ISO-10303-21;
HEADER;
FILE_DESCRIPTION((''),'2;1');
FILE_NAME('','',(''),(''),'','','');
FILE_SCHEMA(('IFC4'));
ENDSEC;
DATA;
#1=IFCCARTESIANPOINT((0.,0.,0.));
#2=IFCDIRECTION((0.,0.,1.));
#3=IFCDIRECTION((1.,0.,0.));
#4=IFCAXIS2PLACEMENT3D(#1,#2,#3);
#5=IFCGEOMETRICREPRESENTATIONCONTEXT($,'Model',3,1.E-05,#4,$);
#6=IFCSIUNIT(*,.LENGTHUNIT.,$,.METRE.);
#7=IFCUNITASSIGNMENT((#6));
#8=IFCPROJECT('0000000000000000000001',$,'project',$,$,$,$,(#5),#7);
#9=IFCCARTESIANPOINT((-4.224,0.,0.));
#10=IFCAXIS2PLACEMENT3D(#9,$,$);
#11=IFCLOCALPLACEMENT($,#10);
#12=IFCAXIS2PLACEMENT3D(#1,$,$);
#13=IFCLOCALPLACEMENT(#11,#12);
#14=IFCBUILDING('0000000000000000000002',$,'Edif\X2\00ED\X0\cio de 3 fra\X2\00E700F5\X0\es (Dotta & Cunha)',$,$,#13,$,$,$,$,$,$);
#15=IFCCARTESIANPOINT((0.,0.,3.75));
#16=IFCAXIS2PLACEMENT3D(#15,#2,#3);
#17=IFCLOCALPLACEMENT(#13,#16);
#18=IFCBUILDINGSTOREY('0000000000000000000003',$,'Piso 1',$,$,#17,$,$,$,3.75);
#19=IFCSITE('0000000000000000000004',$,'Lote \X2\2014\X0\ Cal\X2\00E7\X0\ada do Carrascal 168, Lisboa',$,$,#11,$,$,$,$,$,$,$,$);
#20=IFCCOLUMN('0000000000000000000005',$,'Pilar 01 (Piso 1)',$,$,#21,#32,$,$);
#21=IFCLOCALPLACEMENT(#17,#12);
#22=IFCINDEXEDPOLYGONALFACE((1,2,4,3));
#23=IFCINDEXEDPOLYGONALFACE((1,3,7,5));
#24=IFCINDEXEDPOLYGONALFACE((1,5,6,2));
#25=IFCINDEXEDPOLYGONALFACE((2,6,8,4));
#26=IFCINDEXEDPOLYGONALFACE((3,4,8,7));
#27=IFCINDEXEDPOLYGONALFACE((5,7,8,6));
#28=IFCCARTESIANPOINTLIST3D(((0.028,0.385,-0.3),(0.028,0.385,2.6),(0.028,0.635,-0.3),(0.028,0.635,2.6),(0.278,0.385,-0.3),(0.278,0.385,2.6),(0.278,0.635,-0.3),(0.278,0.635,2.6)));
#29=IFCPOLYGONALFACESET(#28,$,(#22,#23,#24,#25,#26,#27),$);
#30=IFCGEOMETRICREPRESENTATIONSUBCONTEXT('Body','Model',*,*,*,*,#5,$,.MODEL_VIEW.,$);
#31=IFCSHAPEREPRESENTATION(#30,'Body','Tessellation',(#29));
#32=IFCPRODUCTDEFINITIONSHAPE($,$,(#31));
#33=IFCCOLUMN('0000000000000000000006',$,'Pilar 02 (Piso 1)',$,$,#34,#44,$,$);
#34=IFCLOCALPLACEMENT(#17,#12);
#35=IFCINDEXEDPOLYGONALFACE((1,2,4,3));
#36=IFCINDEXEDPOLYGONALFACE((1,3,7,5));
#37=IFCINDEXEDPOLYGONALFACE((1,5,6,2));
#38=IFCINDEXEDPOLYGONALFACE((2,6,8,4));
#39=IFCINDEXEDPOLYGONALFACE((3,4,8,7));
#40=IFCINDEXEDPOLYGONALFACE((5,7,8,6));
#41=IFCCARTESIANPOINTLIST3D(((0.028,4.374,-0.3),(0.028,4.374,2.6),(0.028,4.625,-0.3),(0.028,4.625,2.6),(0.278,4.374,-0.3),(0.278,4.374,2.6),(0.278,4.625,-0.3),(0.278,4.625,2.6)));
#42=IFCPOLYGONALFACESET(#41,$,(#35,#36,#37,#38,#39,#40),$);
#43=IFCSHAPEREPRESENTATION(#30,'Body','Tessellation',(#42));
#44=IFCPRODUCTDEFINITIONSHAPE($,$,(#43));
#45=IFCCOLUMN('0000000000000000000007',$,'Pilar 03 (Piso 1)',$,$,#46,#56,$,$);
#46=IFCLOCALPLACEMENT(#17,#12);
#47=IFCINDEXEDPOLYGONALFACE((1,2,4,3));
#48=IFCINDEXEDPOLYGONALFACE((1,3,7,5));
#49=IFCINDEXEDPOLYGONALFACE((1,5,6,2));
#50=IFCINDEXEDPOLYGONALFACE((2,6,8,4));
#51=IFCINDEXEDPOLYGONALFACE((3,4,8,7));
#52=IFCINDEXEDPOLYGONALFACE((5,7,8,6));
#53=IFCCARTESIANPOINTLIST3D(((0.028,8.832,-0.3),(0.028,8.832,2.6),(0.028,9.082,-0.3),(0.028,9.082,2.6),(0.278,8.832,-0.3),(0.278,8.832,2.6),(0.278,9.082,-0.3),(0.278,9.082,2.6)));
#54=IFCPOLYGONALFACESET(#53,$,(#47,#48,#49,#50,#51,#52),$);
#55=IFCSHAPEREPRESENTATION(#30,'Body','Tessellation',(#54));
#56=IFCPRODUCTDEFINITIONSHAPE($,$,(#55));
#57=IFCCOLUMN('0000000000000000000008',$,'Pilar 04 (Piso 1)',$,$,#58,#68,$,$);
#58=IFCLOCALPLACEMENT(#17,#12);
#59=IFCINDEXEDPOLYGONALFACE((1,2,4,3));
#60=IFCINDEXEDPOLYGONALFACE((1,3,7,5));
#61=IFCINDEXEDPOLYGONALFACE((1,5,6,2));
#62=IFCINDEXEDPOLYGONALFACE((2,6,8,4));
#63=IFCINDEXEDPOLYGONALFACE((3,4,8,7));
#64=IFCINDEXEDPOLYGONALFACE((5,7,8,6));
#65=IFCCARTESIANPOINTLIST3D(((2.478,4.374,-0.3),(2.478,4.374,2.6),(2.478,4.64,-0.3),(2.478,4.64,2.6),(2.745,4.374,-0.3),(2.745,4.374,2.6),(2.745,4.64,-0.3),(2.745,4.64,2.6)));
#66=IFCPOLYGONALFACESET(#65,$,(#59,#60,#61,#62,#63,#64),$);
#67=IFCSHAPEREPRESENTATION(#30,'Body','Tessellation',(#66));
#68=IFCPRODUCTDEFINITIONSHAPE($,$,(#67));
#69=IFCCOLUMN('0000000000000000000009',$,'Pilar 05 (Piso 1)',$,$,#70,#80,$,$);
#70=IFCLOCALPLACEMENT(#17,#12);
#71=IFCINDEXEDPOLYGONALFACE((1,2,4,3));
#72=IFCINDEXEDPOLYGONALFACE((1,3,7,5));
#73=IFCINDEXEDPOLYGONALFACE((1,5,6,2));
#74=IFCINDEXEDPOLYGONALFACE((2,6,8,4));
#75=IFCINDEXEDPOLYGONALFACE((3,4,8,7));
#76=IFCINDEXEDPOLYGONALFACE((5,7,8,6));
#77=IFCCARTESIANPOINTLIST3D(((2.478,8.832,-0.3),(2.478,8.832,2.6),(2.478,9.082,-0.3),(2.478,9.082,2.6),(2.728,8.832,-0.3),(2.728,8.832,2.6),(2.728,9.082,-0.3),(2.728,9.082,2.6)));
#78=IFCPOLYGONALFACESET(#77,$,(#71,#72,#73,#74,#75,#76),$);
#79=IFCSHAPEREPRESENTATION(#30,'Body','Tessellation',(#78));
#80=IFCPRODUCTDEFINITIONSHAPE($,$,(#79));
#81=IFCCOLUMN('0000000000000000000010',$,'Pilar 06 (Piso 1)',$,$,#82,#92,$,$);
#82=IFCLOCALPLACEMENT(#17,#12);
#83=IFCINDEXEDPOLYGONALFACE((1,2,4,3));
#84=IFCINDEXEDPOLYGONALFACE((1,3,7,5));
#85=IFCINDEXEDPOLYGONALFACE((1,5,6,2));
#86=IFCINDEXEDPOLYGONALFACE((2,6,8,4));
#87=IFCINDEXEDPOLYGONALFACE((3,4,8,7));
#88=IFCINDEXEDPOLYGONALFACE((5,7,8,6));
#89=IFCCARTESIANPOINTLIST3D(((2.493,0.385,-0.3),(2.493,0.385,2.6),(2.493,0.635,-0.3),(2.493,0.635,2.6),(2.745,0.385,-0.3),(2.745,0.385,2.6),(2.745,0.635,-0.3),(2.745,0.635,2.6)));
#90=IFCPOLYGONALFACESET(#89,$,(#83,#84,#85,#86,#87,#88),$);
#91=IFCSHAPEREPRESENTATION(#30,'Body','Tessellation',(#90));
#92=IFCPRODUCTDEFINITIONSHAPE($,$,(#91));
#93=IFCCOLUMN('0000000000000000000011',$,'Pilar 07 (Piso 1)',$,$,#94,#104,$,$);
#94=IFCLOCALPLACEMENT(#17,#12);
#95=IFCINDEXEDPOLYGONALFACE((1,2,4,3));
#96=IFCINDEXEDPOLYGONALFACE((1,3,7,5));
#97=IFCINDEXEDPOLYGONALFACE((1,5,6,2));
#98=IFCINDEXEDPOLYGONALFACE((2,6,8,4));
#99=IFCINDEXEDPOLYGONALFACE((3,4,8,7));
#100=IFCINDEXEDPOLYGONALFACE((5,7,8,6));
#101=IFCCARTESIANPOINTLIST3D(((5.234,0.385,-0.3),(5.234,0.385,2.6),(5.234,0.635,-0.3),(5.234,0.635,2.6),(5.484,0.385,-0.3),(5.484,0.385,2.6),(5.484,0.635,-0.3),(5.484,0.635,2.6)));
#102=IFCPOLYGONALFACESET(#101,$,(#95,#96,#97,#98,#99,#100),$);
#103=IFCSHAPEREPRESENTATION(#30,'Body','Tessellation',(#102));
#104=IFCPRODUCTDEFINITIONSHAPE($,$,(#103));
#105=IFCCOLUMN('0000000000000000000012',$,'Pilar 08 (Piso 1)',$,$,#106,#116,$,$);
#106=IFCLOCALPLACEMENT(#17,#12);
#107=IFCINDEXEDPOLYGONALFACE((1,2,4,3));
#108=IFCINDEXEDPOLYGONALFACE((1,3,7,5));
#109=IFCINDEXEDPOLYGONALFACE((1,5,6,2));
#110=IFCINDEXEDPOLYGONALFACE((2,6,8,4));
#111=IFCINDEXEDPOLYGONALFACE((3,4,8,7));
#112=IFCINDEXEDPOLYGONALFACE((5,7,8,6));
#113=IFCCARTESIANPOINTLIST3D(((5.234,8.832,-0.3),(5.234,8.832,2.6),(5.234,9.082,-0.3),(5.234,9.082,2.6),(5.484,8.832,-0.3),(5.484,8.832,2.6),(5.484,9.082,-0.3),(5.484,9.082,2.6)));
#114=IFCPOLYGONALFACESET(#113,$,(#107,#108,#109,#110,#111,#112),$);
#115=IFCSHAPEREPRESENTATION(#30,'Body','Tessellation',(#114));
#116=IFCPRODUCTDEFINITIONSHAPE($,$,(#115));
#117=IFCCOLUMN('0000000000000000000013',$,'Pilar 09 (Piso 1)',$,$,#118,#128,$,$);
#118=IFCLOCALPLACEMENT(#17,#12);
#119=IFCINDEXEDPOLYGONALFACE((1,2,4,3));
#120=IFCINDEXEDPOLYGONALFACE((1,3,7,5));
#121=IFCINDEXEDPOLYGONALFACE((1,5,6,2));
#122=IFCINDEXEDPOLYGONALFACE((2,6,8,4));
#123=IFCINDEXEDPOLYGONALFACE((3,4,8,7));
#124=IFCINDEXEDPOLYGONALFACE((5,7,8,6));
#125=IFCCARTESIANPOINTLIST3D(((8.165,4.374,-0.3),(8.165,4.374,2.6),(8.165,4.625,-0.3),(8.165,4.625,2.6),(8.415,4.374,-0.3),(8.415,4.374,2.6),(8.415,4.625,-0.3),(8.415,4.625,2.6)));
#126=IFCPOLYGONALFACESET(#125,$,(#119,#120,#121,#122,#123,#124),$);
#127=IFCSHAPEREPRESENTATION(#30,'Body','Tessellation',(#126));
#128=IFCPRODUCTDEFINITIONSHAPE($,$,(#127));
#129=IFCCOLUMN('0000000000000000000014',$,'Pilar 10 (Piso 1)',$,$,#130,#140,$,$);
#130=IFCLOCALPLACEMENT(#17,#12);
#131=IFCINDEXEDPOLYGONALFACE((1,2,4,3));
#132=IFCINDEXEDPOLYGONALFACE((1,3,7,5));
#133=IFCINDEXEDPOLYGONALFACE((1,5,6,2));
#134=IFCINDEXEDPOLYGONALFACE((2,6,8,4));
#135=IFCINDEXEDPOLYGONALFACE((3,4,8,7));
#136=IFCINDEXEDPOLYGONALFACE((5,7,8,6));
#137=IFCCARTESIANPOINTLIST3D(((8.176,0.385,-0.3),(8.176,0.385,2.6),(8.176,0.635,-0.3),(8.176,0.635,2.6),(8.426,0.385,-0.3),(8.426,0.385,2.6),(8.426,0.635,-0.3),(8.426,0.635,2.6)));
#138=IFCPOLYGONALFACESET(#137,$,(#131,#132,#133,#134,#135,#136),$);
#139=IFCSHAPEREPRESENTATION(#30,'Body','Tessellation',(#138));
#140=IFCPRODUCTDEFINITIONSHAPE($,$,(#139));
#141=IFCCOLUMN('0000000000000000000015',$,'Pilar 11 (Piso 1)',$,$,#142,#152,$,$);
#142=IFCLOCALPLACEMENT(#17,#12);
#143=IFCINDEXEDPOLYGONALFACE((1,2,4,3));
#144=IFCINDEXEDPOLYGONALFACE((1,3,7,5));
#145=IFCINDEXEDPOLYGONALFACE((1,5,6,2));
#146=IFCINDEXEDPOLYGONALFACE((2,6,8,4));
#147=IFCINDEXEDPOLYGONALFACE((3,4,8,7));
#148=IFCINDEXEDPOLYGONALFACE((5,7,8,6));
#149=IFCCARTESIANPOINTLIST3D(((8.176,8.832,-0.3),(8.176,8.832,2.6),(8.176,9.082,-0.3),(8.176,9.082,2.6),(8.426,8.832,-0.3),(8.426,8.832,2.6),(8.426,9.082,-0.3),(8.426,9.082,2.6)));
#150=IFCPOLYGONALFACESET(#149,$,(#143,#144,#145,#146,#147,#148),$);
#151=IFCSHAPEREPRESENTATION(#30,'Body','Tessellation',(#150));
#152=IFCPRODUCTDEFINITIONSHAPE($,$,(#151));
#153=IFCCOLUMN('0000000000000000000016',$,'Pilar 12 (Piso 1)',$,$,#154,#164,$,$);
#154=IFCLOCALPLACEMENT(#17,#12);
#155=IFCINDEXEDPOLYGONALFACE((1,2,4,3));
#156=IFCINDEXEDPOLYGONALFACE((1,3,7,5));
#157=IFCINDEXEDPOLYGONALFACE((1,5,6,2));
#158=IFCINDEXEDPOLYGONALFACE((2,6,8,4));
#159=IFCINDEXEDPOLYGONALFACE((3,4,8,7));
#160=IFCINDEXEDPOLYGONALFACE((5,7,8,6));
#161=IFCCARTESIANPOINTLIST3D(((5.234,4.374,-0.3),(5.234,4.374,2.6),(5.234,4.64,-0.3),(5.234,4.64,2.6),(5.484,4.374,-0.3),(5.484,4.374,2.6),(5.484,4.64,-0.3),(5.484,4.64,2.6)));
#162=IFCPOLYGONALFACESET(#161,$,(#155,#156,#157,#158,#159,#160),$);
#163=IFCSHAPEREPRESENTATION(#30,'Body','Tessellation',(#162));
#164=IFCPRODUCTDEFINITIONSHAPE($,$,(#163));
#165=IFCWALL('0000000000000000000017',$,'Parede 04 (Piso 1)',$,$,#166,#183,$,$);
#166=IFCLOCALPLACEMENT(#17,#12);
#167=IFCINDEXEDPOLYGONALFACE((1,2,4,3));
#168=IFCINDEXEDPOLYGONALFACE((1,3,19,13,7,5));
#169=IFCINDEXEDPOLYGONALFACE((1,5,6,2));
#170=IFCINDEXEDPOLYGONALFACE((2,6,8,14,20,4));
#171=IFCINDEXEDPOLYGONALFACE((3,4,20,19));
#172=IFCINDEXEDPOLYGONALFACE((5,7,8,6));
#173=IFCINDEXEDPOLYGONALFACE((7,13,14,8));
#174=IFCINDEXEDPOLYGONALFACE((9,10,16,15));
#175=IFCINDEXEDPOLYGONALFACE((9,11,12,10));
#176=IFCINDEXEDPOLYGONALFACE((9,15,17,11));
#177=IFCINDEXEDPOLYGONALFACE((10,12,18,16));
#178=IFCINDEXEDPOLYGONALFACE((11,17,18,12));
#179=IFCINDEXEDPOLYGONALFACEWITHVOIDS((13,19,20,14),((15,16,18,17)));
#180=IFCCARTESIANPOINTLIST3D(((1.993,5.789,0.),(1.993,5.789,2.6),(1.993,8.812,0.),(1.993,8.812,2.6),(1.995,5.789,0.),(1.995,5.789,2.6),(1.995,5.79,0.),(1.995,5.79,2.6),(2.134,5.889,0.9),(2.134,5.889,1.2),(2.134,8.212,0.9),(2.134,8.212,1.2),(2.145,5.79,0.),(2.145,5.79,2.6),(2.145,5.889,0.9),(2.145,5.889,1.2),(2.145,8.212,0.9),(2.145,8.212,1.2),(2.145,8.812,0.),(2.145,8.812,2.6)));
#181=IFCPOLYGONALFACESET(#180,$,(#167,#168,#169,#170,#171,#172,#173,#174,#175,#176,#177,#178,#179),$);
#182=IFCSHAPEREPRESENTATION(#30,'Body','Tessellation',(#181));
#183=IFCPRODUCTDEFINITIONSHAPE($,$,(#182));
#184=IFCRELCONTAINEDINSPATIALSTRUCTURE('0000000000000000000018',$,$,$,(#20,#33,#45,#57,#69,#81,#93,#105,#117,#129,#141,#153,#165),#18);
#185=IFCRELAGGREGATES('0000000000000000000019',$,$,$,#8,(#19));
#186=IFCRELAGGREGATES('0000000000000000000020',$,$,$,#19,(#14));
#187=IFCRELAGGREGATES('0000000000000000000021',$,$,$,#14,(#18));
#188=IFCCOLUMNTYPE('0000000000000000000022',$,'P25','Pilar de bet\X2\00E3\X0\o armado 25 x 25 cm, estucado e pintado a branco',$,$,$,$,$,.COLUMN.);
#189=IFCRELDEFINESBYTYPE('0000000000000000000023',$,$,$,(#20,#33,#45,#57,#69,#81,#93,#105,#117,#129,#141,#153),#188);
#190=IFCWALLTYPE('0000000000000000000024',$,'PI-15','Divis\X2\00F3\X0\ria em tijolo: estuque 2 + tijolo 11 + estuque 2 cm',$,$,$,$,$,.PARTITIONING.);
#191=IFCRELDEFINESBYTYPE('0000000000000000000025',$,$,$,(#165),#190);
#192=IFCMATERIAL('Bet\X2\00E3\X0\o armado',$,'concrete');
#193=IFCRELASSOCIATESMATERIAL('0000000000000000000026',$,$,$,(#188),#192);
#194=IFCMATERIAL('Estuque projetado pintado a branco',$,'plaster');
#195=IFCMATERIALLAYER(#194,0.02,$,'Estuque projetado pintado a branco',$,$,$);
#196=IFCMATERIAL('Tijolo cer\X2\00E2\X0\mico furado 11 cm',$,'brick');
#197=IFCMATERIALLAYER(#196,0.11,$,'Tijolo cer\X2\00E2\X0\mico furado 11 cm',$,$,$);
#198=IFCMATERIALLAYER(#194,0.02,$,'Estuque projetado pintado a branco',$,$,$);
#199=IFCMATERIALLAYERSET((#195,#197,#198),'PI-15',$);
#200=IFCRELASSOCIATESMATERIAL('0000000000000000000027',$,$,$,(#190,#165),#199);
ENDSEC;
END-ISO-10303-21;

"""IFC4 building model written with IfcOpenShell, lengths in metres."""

from ifc_helpers import new_model, si_unit, frame, origin, origin_with_axes, place, context, subcontext, project, spatial, line, indexed_curve, outline, extrude, material, layer, layer_set, layer_usage, type_object, element, save


model = new_model("IFC4")

# Units and contexts
model_context = context("Model", 3, precision=1e-05, world=origin_with_axes())
body_context = subcontext(model_context, "Body", "Model", "MODEL_VIEW")
ifc_project = project(units=[si_unit("LENGTHUNIT", "METRE")], contexts=[model_context])

# Site, building, storey
site_placement = place(None, frame((-4.224, 0.0, 0.0)))
site = spatial("IfcSite", under=ifc_project, at=site_placement, Name="Lote — Calçada do Carrascal 168, Lisboa")
building_placement = place(site_placement, origin())
building = spatial("IfcBuilding", under=site, at=building_placement, Name="Edifício de 3 frações (Dotta & Cunha)")
storey_placement = place(building_placement, frame((0.0, 0.0, 3.75), z_axis=(0.0, 0.0, 1.0), x_axis=(1.0, 0.0, 0.0)))
storey = spatial("IfcBuildingStorey", under=building, at=storey_placement, Name="Piso 1", Elevation=3.75)

# Columns
ifc_material_1 = material(Name="Betão armado", Category="concrete")
column_type = type_object("IfcColumnType", Name="P25", Description="Pilar de betão armado 25 x 25 cm, estucado e pintado a branco", PredefinedType="COLUMN", material=ifc_material_1)
column_1_placement = place(storey_placement, frame((0.0, 0.0, -0.3), z_axis=(0.0, 0.0, 1.0), x_axis=(1.0, 0.0, 0.0)))
element("IfcColumn", 1, at=column_1_placement, inside=storey, type_object=column_type, Name="Pilar 01 (Piso 1)", context=body_context, shape_type="SweptSolid", body=[
    extrude(outline(indexed_curve([(0.278, 0.385), (0.028, 0.385), (0.028, 0.635), (0.278, 0.635)], segments=[line(1, 2, 3, 4, 1)])), origin_with_axes(), (0.0, 0.0, 1.0), 2.9),
])
column_2_placement = place(storey_placement, frame((0.0, 0.0, -0.3), z_axis=(0.0, 0.0, 1.0), x_axis=(1.0, 0.0, 0.0)))
element("IfcColumn", 2, at=column_2_placement, inside=storey, type_object=column_type, Name="Pilar 02 (Piso 1)", context=body_context, shape_type="SweptSolid", body=[
    extrude(outline(indexed_curve([(0.278, 4.374), (0.028, 4.374), (0.028, 4.625), (0.278, 4.625)], segments=[line(1, 2, 3, 4, 1)])), origin_with_axes(), (0.0, 0.0, 1.0), 2.9),
])
column_3_placement = place(storey_placement, frame((0.0, 0.0, -0.3), z_axis=(0.0, 0.0, 1.0), x_axis=(1.0, 0.0, 0.0)))
element("IfcColumn", 3, at=column_3_placement, inside=storey, type_object=column_type, Name="Pilar 03 (Piso 1)", context=body_context, shape_type="SweptSolid", body=[
    extrude(outline(indexed_curve([(0.028, 9.082), (0.278, 9.082), (0.278, 8.832), (0.028, 8.832)], segments=[line(1, 2, 3, 4, 1)])), origin_with_axes(), (0.0, 0.0, 1.0), 2.9),
])
column_4_placement = place(storey_placement, frame((0.0, 0.0, -0.3), z_axis=(0.0, 0.0, 1.0), x_axis=(1.0, 0.0, 0.0)))
element("IfcColumn", 4, at=column_4_placement, inside=storey, type_object=column_type, Name="Pilar 04 (Piso 1)", context=body_context, shape_type="SweptSolid", body=[
    extrude(outline(indexed_curve([(2.478, 4.64), (2.745, 4.64), (2.745, 4.374), (2.478, 4.374)], segments=[line(1, 2, 3, 4, 1)])), origin_with_axes(), (0.0, 0.0, 1.0), 2.9),
])
column_5_placement = place(storey_placement, frame((0.0, 0.0, -0.3), z_axis=(0.0, 0.0, 1.0), x_axis=(1.0, 0.0, 0.0)))
element("IfcColumn", 5, at=column_5_placement, inside=storey, type_object=column_type, Name="Pilar 05 (Piso 1)", context=body_context, shape_type="SweptSolid", body=[
    extrude(outline(indexed_curve([(2.478, 9.082), (2.728, 9.082), (2.728, 8.832), (2.478, 8.832)], segments=[line(1, 2, 3, 4, 1)])), origin_with_axes(), (0.0, 0.0, 1.0), 2.9),
])
column_6_placement = place(storey_placement, frame((0.0, 0.0, -0.3), z_axis=(0.0, 0.0, 1.0), x_axis=(1.0, 0.0, 0.0)))
element("IfcColumn", 6, at=column_6_placement, inside=storey, type_object=column_type, Name="Pilar 06 (Piso 1)", context=body_context, shape_type="SweptSolid", body=[
    extrude(outline(indexed_curve([(2.493, 0.385), (2.493, 0.635), (2.745, 0.635), (2.745, 0.385)], segments=[line(1, 2, 3, 4, 1)])), origin_with_axes(), (0.0, 0.0, 1.0), 2.9),
])
column_7_placement = place(storey_placement, frame((0.0, 0.0, -0.3), z_axis=(0.0, 0.0, 1.0), x_axis=(1.0, 0.0, 0.0)))
element("IfcColumn", 7, at=column_7_placement, inside=storey, type_object=column_type, Name="Pilar 07 (Piso 1)", context=body_context, shape_type="SweptSolid", body=[
    extrude(outline(indexed_curve([(5.234, 0.385), (5.234, 0.635), (5.484, 0.635), (5.484, 0.385)], segments=[line(1, 2, 3, 4, 1)])), origin_with_axes(), (0.0, 0.0, 1.0), 2.9),
])
column_8_placement = place(storey_placement, frame((0.0, 0.0, -0.3), z_axis=(0.0, 0.0, 1.0), x_axis=(1.0, 0.0, 0.0)))
element("IfcColumn", 8, at=column_8_placement, inside=storey, type_object=column_type, Name="Pilar 08 (Piso 1)", context=body_context, shape_type="SweptSolid", body=[
    extrude(outline(indexed_curve([(5.234, 9.082), (5.484, 9.082), (5.484, 8.832), (5.234, 8.832)], segments=[line(1, 2, 3, 4, 1)])), origin_with_axes(), (0.0, 0.0, 1.0), 2.9),
])
column_9_placement = place(storey_placement, frame((0.0, 0.0, -0.3), z_axis=(0.0, 0.0, 1.0), x_axis=(1.0, 0.0, 0.0)))
element("IfcColumn", 9, at=column_9_placement, inside=storey, type_object=column_type, Name="Pilar 09 (Piso 1)", context=body_context, shape_type="SweptSolid", body=[
    extrude(outline(indexed_curve([(8.165, 4.625), (8.415, 4.625), (8.415, 4.374), (8.165, 4.374)], segments=[line(1, 2, 3, 4, 1)])), origin_with_axes(), (0.0, 0.0, 1.0), 2.9),
])
column_10_placement = place(storey_placement, frame((0.0, 0.0, -0.3), z_axis=(0.0, 0.0, 1.0), x_axis=(1.0, 0.0, 0.0)))
element("IfcColumn", 10, at=column_10_placement, inside=storey, type_object=column_type, Name="Pilar 10 (Piso 1)", context=body_context, shape_type="SweptSolid", body=[
    extrude(outline(indexed_curve([(8.176, 0.635), (8.426, 0.635), (8.426, 0.385), (8.176, 0.385)], segments=[line(1, 2, 3, 4, 1)])), origin_with_axes(), (0.0, 0.0, 1.0), 2.9),
])
column_11_placement = place(storey_placement, frame((0.0, 0.0, -0.3), z_axis=(0.0, 0.0, 1.0), x_axis=(1.0, 0.0, 0.0)))
element("IfcColumn", 11, at=column_11_placement, inside=storey, type_object=column_type, Name="Pilar 11 (Piso 1)", context=body_context, shape_type="SweptSolid", body=[
    extrude(outline(indexed_curve([(8.176, 9.082), (8.426, 9.082), (8.426, 8.832), (8.176, 8.832)], segments=[line(1, 2, 3, 4, 1)])), origin_with_axes(), (0.0, 0.0, 1.0), 2.9),
])
column_12_placement = place(storey_placement, frame((0.0, 0.0, -0.3), z_axis=(0.0, 0.0, 1.0), x_axis=(1.0, 0.0, 0.0)))
element("IfcColumn", 12, at=column_12_placement, inside=storey, type_object=column_type, Name="Pilar 12 (Piso 1)", context=body_context, shape_type="SweptSolid", body=[
    extrude(outline(indexed_curve([(5.234, 4.374), (5.234, 4.64), (5.484, 4.64), (5.484, 4.374)], segments=[line(1, 2, 3, 4, 1)])), origin_with_axes(), (0.0, 0.0, 1.0), 2.9),
])

# Wall, opening
ifc_material_2 = material(Name="Estuque projetado pintado a branco", Category="plaster")
ifc_layer_1 = layer(ifc_material_2, 0.02, Name="Estuque projetado pintado a branco")
ifc_material_3 = material(Name="Tijolo cerâmico furado 11 cm", Category="brick")
ifc_layer_2 = layer(ifc_material_3, 0.11, Name="Tijolo cerâmico furado 11 cm")
ifc_layer_3 = layer(ifc_material_2, 0.02, Name="Estuque projetado pintado a branco")
ifc_layer_set_1 = layer_set([ifc_layer_1, ifc_layer_2, ifc_layer_3], Name="PI-15")
ifc_layer_usage_1 = layer_usage(ifc_layer_set_1, "AXIS2", "POSITIVE", 0.0)
wall_type_1 = type_object("IfcWallType", Name="PI-15", Description="Divisória em tijolo: estuque 2 + tijolo 11 + estuque 2 cm", PredefinedType="PARTITIONING", material=ifc_layer_set_1)
wall_1_placement = place(storey_placement, origin_with_axes())
wall_1 = element("IfcWall", 13, at=wall_1_placement, inside=storey, type_object=wall_type_1, material=ifc_layer_usage_1, Name="Parede 04 (Piso 1)", context=body_context, shape_type="SweptSolid", body=[
    extrude(outline(indexed_curve([(1.995, 5.789), (1.993, 5.789), (1.993, 5.79), (1.993, 8.812), (2.145, 8.812), (2.145, 5.79), (1.995, 5.79)], segments=[line(1, 2, 3, 4, 5, 6, 7, 1)])), origin_with_axes(), (0.0, 0.0, 1.0), 2.6),
])
opening_1_placement = place(wall_1_placement, frame((0.0, 0.0, 0.9), z_axis=(0.0, 0.0, 1.0), x_axis=(1.0, 0.0, 0.0)))
element("IfcOpeningElement", 14, at=opening_1_placement, cuts=wall_1, PredefinedType="RECESS", context=body_context, shape_type="SweptSolid", body=[
    extrude(outline(indexed_curve([(2.15, 5.889), (2.15, 8.212), (2.134, 8.212), (2.134, 5.889)], segments=[line(1, 2, 3, 4, 1)])), origin_with_axes(), (0.0, 0.0, 1.0), 0.3),
])

save(model, "model.ifc")
